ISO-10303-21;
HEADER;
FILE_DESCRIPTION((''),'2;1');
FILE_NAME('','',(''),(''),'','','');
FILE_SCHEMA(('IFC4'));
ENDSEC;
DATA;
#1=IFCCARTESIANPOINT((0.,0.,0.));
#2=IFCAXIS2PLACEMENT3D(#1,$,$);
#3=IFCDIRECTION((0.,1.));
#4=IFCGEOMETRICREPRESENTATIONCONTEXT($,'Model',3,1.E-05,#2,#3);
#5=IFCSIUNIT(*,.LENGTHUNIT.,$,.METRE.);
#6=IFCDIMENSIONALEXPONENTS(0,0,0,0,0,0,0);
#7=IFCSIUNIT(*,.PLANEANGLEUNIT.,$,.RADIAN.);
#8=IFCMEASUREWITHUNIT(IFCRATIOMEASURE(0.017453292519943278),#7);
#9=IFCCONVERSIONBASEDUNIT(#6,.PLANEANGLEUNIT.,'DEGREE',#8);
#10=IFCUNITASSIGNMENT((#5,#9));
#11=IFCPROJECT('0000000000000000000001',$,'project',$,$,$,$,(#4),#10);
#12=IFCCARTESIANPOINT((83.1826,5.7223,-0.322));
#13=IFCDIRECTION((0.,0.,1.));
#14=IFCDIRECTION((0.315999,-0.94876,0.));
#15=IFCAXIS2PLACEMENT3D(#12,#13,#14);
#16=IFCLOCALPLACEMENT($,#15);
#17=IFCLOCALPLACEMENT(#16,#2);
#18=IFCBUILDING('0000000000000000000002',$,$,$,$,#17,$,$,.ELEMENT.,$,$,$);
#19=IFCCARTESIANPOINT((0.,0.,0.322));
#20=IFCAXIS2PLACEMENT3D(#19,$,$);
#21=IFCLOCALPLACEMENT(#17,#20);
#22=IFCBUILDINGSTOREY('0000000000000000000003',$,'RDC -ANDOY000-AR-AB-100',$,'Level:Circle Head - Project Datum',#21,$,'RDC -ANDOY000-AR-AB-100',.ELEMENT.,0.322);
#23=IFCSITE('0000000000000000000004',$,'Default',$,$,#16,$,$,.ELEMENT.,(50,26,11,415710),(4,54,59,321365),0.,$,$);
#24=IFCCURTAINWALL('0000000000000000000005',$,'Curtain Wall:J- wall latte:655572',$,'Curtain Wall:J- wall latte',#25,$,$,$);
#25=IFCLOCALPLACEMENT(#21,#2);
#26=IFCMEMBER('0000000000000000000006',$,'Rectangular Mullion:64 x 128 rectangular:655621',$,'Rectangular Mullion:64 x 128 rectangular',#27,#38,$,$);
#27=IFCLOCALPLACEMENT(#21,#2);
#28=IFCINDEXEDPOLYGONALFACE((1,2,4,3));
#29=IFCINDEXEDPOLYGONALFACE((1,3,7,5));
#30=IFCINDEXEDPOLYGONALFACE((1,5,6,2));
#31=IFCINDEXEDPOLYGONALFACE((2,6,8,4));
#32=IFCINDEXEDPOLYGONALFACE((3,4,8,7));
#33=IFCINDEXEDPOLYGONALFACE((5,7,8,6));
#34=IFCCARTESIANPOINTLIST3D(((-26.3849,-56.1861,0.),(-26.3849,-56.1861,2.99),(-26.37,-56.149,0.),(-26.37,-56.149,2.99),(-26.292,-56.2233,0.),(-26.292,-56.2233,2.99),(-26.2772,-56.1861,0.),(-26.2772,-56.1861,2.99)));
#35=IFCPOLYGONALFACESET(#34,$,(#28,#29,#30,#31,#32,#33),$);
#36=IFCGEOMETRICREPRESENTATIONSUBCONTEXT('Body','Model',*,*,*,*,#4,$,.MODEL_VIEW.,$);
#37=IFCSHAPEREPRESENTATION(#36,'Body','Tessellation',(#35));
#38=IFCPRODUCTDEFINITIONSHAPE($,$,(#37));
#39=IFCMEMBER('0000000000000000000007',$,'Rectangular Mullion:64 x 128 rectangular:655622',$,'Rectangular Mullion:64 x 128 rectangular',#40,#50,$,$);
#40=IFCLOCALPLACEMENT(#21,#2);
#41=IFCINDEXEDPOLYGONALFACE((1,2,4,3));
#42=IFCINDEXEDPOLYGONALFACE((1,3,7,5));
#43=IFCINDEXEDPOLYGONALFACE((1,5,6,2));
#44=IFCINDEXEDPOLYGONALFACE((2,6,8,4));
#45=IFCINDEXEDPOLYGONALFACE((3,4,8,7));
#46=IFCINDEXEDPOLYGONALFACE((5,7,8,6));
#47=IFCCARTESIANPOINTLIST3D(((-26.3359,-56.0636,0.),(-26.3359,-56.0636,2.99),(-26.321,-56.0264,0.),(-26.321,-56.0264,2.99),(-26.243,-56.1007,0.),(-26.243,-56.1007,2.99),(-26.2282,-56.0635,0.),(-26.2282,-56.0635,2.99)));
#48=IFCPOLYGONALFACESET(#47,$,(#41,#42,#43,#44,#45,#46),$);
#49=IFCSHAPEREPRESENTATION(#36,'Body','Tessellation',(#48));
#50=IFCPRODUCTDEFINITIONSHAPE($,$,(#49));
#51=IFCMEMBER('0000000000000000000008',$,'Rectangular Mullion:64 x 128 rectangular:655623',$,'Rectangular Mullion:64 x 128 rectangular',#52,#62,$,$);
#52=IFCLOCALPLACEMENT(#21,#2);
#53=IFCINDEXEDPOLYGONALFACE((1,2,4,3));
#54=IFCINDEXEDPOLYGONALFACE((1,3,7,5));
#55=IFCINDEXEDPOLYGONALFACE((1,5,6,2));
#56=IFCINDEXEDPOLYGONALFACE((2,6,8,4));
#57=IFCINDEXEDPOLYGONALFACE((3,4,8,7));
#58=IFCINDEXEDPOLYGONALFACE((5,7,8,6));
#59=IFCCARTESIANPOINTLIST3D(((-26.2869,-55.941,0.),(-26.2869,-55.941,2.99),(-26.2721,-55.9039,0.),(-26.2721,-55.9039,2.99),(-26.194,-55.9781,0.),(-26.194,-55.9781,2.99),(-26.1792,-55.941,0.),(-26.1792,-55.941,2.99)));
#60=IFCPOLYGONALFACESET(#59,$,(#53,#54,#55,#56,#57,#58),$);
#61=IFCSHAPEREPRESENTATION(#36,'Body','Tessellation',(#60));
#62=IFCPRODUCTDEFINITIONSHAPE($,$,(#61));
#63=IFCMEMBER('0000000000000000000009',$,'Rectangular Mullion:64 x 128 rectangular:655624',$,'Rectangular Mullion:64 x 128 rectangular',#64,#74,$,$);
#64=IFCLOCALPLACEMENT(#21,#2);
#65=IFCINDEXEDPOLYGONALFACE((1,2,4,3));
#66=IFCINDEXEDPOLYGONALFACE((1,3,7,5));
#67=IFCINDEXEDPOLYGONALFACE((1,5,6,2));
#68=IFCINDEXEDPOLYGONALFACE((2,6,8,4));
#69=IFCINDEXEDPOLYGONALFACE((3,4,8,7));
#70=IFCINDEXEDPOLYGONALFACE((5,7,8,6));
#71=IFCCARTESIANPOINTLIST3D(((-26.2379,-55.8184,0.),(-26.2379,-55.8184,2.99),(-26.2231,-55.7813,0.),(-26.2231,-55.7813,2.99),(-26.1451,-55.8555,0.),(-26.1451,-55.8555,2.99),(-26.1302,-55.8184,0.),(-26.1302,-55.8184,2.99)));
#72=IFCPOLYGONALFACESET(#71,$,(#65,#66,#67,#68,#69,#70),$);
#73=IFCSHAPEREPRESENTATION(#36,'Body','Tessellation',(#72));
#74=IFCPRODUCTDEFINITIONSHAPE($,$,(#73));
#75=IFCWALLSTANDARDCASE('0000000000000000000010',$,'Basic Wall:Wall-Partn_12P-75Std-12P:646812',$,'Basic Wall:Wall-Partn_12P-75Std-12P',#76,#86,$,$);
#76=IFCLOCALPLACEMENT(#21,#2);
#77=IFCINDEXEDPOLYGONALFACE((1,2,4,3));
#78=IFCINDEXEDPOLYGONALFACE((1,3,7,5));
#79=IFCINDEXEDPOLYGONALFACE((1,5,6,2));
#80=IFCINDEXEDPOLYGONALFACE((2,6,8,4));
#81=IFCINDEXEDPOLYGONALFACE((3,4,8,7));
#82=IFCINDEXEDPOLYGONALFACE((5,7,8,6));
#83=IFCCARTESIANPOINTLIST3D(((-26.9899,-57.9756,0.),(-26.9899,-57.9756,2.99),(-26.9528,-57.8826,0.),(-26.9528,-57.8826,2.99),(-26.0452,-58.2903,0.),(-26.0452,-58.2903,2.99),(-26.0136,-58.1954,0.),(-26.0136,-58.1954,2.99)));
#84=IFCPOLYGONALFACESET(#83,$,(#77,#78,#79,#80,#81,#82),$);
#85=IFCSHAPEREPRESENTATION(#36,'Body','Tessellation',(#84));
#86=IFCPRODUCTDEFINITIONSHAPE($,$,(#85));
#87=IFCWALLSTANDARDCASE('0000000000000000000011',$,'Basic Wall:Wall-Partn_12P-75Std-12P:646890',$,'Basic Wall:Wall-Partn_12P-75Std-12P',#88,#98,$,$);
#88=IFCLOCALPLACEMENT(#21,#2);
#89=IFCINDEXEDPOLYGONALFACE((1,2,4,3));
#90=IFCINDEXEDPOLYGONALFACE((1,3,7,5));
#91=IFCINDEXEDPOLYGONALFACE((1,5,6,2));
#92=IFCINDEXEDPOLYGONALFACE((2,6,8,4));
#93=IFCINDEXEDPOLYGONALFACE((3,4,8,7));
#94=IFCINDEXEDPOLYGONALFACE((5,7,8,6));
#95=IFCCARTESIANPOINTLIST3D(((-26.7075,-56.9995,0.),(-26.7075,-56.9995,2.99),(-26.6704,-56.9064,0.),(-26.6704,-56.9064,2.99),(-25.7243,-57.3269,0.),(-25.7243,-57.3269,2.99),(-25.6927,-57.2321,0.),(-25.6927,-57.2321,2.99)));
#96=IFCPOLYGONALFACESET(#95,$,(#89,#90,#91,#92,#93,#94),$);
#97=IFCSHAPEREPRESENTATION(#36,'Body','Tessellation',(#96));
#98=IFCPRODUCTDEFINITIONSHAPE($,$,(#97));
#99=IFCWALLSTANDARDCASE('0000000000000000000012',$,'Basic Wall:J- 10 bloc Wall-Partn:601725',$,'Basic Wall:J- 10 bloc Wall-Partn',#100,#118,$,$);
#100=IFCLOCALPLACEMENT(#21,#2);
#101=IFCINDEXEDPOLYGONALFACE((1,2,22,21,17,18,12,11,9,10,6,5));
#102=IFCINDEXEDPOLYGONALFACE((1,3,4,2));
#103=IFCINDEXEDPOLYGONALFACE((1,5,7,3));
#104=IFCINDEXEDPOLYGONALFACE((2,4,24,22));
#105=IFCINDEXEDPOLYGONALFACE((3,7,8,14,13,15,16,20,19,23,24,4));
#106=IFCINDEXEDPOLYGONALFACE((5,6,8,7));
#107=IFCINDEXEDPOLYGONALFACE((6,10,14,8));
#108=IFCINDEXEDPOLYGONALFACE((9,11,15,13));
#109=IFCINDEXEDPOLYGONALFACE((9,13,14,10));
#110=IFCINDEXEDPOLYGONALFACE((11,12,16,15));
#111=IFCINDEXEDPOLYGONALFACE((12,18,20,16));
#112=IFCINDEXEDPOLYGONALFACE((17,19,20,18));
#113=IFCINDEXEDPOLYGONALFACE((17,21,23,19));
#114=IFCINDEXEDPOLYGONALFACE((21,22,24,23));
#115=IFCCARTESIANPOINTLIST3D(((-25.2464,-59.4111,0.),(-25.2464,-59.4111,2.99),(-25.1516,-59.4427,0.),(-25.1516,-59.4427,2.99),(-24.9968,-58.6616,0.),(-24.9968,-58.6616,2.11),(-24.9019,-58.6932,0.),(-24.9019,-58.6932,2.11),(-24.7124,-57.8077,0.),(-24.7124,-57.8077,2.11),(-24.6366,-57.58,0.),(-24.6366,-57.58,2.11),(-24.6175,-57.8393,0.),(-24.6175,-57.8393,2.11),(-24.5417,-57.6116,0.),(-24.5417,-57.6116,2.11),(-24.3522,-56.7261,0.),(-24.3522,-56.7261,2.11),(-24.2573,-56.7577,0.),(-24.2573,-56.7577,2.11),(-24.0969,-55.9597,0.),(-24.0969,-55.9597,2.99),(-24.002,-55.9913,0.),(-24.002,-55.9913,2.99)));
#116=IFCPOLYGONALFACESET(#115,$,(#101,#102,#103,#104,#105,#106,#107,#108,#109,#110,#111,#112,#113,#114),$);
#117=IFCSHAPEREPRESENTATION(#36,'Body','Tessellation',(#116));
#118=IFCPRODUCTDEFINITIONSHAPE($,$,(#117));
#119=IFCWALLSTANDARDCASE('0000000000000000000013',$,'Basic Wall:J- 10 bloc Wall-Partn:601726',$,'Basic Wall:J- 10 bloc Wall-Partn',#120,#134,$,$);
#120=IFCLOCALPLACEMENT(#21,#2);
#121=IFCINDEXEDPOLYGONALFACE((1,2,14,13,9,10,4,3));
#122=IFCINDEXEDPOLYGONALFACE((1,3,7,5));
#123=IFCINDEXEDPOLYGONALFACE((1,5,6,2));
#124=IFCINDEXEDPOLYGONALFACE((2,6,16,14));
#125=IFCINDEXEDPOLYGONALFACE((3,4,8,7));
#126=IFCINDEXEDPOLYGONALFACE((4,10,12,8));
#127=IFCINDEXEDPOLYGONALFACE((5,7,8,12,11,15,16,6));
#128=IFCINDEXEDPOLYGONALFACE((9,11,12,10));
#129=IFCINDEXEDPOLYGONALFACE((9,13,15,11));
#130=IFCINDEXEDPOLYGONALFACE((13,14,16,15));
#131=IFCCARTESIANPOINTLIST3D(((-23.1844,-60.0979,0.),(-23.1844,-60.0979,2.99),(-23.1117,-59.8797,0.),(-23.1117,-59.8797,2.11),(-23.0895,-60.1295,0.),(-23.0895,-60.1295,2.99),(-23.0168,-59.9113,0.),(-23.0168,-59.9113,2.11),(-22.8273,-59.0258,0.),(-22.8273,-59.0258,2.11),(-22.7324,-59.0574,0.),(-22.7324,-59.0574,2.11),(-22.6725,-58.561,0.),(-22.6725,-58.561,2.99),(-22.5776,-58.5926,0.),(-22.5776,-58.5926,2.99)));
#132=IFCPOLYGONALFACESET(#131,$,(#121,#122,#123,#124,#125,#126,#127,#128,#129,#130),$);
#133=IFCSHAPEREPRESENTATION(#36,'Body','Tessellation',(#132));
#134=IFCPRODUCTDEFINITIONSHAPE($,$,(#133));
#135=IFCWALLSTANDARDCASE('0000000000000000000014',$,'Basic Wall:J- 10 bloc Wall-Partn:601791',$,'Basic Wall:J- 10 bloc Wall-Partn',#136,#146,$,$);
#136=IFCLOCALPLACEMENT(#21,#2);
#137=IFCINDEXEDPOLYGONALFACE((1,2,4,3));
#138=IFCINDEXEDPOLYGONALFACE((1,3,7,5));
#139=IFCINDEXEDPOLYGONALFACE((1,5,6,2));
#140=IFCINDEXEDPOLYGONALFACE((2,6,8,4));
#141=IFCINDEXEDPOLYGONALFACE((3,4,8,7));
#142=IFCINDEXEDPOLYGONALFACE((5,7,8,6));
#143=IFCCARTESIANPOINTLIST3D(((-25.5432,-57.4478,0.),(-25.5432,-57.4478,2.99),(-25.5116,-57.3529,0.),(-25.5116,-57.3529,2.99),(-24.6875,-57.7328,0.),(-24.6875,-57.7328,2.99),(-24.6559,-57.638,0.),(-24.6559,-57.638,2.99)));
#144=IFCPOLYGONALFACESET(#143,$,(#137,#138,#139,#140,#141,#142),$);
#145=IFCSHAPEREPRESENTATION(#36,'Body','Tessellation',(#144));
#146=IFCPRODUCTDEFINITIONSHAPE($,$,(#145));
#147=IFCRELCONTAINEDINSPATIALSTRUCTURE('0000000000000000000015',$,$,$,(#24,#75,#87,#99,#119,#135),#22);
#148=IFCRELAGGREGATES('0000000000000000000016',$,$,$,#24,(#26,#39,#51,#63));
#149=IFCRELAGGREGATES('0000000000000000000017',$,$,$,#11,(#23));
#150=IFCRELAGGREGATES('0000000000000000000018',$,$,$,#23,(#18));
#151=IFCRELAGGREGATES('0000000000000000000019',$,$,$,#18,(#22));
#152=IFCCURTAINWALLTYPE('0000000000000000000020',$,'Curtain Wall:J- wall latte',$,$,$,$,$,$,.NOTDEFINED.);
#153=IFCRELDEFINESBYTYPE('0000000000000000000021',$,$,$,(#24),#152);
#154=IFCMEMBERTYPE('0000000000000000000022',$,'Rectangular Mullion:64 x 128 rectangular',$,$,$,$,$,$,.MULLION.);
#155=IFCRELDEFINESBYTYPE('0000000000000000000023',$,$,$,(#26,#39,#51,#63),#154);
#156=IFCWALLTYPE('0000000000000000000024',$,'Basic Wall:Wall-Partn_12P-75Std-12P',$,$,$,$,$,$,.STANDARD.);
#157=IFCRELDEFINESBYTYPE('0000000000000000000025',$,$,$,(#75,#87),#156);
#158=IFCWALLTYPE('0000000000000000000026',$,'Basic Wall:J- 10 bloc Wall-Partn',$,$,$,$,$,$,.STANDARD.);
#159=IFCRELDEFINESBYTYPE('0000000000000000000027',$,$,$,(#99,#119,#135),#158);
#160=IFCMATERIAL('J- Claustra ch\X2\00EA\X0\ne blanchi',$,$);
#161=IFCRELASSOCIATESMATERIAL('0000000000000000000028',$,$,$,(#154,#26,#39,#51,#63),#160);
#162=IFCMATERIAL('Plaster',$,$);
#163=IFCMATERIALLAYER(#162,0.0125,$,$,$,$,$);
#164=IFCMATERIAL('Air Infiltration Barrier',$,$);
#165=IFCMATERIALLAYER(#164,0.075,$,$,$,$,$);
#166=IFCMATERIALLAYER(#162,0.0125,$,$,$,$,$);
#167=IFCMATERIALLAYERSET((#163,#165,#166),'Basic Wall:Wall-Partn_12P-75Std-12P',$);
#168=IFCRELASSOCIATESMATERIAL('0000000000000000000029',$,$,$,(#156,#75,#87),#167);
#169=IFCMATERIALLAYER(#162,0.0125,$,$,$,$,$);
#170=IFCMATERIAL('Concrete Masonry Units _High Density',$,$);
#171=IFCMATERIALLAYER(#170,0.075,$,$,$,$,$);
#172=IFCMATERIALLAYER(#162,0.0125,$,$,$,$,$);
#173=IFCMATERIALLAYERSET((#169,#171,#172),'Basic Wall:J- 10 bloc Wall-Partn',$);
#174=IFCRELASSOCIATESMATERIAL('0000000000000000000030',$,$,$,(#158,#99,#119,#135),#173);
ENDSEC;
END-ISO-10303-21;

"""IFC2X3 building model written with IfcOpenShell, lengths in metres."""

from ifc_helpers import new_model, entity, si_unit, converted_unit, direction, frame, frame_2d, origin, origin_2d_with_axis, place, context, subcontext, project, spatial, polyline, rectangle, outline, extrude, clip, bounded_halfspace, source, transform, mapped, material, layer, layer_set, layer_usage, type_object, type_shapes, element, aggregate, save


model = new_model("IFC2X3")

# Units and contexts
model_context = context("Model", 3, precision=1e-05, world=origin(), true_north=direction((0.0, 1.0)))
body_context = subcontext(model_context, "Body", "Model", "MODEL_VIEW")
ifc_project = project(units=[si_unit("LENGTHUNIT", "METRE"), converted_unit("PLANEANGLEUNIT", "DEGREE", entity("IfcRatioMeasure", 0.017453292519943278), si_unit("PLANEANGLEUNIT", "RADIAN"), dimensions=[0, 0, 0, 0, 0, 0, 0])], contexts=[model_context])

# Site, building, storey
site_placement = place(None, frame((83.1826, 5.7223, -0.322), z_axis=(0.0, 0.0, 1.0), x_axis=(0.315999, -0.94876, 0.0)))
site = spatial("IfcSite", under=ifc_project, at=site_placement, Name="Default", CompositionType="ELEMENT", RefLatitude=(50, 26, 11, 415710), RefLongitude=(4, 54, 59, 321365), RefElevation=0.0)
building_placement = place(site_placement, origin())
building = spatial("IfcBuilding", under=site, at=building_placement, CompositionType="ELEMENT")
storey_placement = place(building_placement, frame((0.0, 0.0, 0.322)))
storey = spatial("IfcBuildingStorey", under=building, at=storey_placement, Name="RDC -ANDOY000-AR-AB-100", ObjectType="Level:Circle Head - Project Datum", LongName="RDC -ANDOY000-AR-AB-100", CompositionType="ELEMENT", Elevation=0.322)

# Curtain wall, members
curtain_wall_type = type_object("IfcCurtainWallType", Name="Curtain Wall:J- wall latte", PredefinedType="NOTDEFINED")
curtain_wall_placement = place(storey_placement, frame((0.0, 0.0, -0.322)))
curtain_wall = element("IfcCurtainWall", 1, at=curtain_wall_placement, inside=storey, type_object=curtain_wall_type, Name="Curtain Wall:J- wall latte:655572", ObjectType="Curtain Wall:J- wall latte")
ifc_material_1 = material(Name="J- Claustra chêne blanchi")
member_type = type_object("IfcMemberType", Name="Rectangular Mullion:64 x 128 rectangular", PredefinedType="MULLION", material=ifc_material_1)
shared_shape_1 = source(origin(), body_context, "Body", "SweptSolid", [
    extrude(rectangle(XDim=0.1, YDim=0.04, at=origin_2d_with_axis()), frame((0.0, 0.0, -2.99), z_axis=(0.0, 0.0, 1.0), x_axis=(0.0, -1.0, 0.0)), (0.0, 0.0, 1.0), 2.99),
])
type_shapes(member_type, [shared_shape_1])
member_1_placement = place(curtain_wall_placement, frame((-26.331, -56.1861, 0.322), z_axis=(0.0, 0.0, -1.0), x_axis=(0.371101, 0.928592, 0.0)))
member_1 = element("IfcMember", 2, at=member_1_placement, type_object=member_type, material=ifc_material_1, Name="Rectangular Mullion:64 x 128 rectangular:655621", ObjectType="Rectangular Mullion:64 x 128 rectangular", context=body_context, shape_type="MappedRepresentation", body=[
    mapped(shared_shape_1, transform((0.0, 0.0, 0.0), scale=1.0)),
])
member_2_placement = place(curtain_wall_placement, frame((-26.282, -56.0636, 0.322), z_axis=(0.0, 0.0, -1.0), x_axis=(0.371101, 0.928592, 0.0)))
member_2 = element("IfcMember", 3, at=member_2_placement, type_object=member_type, material=ifc_material_1, Name="Rectangular Mullion:64 x 128 rectangular:655622", ObjectType="Rectangular Mullion:64 x 128 rectangular", context=body_context, shape_type="MappedRepresentation", body=[
    mapped(shared_shape_1, transform((0.0, 0.0, 0.0), scale=1.0)),
])
member_3_placement = place(curtain_wall_placement, frame((-26.2331, -55.941, 0.322), z_axis=(0.0, 0.0, -1.0), x_axis=(0.371101, 0.928592, 0.0)))
member_3 = element("IfcMember", 4, at=member_3_placement, type_object=member_type, material=ifc_material_1, Name="Rectangular Mullion:64 x 128 rectangular:655623", ObjectType="Rectangular Mullion:64 x 128 rectangular", context=body_context, shape_type="MappedRepresentation", body=[
    mapped(shared_shape_1, transform((0.0, 0.0, 0.0), scale=1.0)),
])
member_4_placement = place(curtain_wall_placement, frame((-26.1841, -55.8184, 0.322), z_axis=(0.0, 0.0, -1.0), x_axis=(0.371101, 0.928592, 0.0)))
member_4 = element("IfcMember", 5, at=member_4_placement, type_object=member_type, material=ifc_material_1, Name="Rectangular Mullion:64 x 128 rectangular:655624", ObjectType="Rectangular Mullion:64 x 128 rectangular", context=body_context, shape_type="MappedRepresentation", body=[
    mapped(shared_shape_1, transform((0.0, 0.0, 0.0), scale=1.0)),
])
aggregate(curtain_wall, [member_1, member_2, member_3, member_4])

# Walls
ifc_material_2 = material(Name="Plaster")
ifc_layer_1 = layer(ifc_material_2, 0.0125)
ifc_material_3 = material(Name="Air Infiltration Barrier")
ifc_layer_2 = layer(ifc_material_3, 0.075)
ifc_layer_3 = layer(ifc_material_2, 0.0125)
ifc_layer_set_1 = layer_set([ifc_layer_1, ifc_layer_2, ifc_layer_3], Name="Basic Wall:Wall-Partn_12P-75Std-12P")
ifc_layer_usage_1 = layer_usage(ifc_layer_set_1, "AXIS2", "NEGATIVE", 0.05)
wall_type_1 = type_object("IfcWallType", Name="Basic Wall:Wall-Partn_12P-75Std-12P", PredefinedType="STANDARD", material=ifc_layer_set_1)
wall_1_placement = place(storey_placement, frame((-26.0294, -58.2428, 0.0), z_axis=(0.0, 0.0, 1.0), x_axis=(-0.948759, 0.316, 0.0)))
element("IfcWallStandardCase", 6, at=wall_1_placement, inside=storey, type_object=wall_type_1, material=ifc_layer_usage_1, Name="Basic Wall:Wall-Partn_12P-75Std-12P:646812", ObjectType="Basic Wall:Wall-Partn_12P-75Std-12P", context=body_context, shape_type="Clipping", body=[
    clip(extrude(outline(polyline([(0.9899, -0.05), (0.9958, 0.05), (0.0, 0.05), (0.0, -0.05), (0.9899, -0.05)])), origin(), (0.0, 0.0, 1.0), 2.99), bounded_halfspace(frame((0.0, -0.05, 2.99), z_axis=(0.0, 0.0, -1.0), x_axis=(-1.0, 0.0, 0.0)), True, frame((0.0, -0.05, 2.99)), polyline([(0.0, 0.0), (0.9899, 0.0), (0.9958, 0.1), (0.0, 0.1), (0.0, 0.0)]))),
])
wall_2_placement = place(storey_placement, frame((-25.7085, -57.2795, 0.0), z_axis=(0.0, 0.0, 1.0), x_axis=(-0.948759, 0.316, 0.0)))
element("IfcWallStandardCase", 7, at=wall_2_placement, inside=storey, type_object=wall_type_1, material=ifc_layer_usage_1, Name="Basic Wall:Wall-Partn_12P-75Std-12P:646890", ObjectType="Basic Wall:Wall-Partn_12P-75Std-12P", context=body_context, shape_type="Clipping", body=[
    clip(extrude(outline(polyline([(1.0304, -0.05), (1.0363, 0.05), (0.9361, 0.05), (0.0, 0.05), (0.0, -0.05), (1.0304, -0.05)])), origin(), (0.0, 0.0, 1.0), 2.99), bounded_halfspace(frame((0.0, -0.05, 2.99), z_axis=(0.0, 0.0, -1.0), x_axis=(-1.0, 0.0, 0.0)), True, frame((0.0, -0.05, 2.99)), polyline([(0.0, 0.0), (1.0304, 0.0), (1.0363, 0.1), (0.9361, 0.1), (0.0, 0.1), (0.0, 0.0)]))),
])

# Wall, openings
ifc_layer_4 = layer(ifc_material_2, 0.0125)
ifc_material_4 = material(Name="Concrete Masonry Units _High Density")
ifc_layer_5 = layer(ifc_material_4, 0.075)
ifc_layer_6 = layer(ifc_material_2, 0.0125)
ifc_layer_set_2 = layer_set([ifc_layer_4, ifc_layer_5, ifc_layer_6], Name="Basic Wall:J- 10 bloc Wall-Partn")
ifc_layer_usage_2 = layer_usage(ifc_layer_set_2, "AXIS2", "NEGATIVE", 0.05)
wall_type_2 = type_object("IfcWallType", Name="Basic Wall:J- 10 bloc Wall-Partn", PredefinedType="STANDARD", material=ifc_layer_set_2)
wall_3_placement = place(storey_placement, frame((-24.0494, -55.9755, 0.0), z_axis=(0.0, 0.0, 1.0), x_axis=(-0.316, -0.948759, 0.0)))
wall_3 = element("IfcWallStandardCase", 8, at=wall_3_placement, inside=storey, type_object=wall_type_2, material=ifc_layer_usage_2, Name="Basic Wall:J- 10 bloc Wall-Partn:601725", ObjectType="Basic Wall:J- 10 bloc Wall-Partn", context=body_context, shape_type="Clipping", body=[
    clip(extrude(rectangle(XDim=3.6379, YDim=0.1, at=frame_2d((1.8189, 0.0), x_axis=(1.0, 0.0))), origin(), (0.0, 0.0, 1.0), 2.99), bounded_halfspace(frame((0.0, -0.05, 2.99), z_axis=(0.0, 0.0, -1.0), x_axis=(0.0, 1.0, 0.0)), True, frame((0.0, -0.05, 2.99)), polyline([(0.0, 0.0), (1.7689, 0.0), (1.8689, 0.0), (3.6379, 0.0), (3.6379, 0.1), (0.0, 0.1), (0.0, 0.0)]))),
])
opening_1_placement = place(wall_3_placement, frame((1.9479, -0.05, 0.0)))
element("IfcOpeningElement", 9, at=opening_1_placement, cuts=wall_3, ObjectType="Opening", context=body_context, shape_type="SweptSolid", body=[
    extrude(rectangle(XDim=2.11, YDim=0.9, at=frame_2d((1.055, 0.45), x_axis=(1.0, 0.0))), frame((0.0, 0.0, 0.0), z_axis=(0.0, 1.0, 0.0), x_axis=(0.0, 0.0, 1.0)), (0.0, 0.0, 1.0), 0.1),
])
opening_2_placement = place(wall_3_placement, frame((0.8079, -0.05, 0.0)))
element("IfcOpeningElement", 10, at=opening_2_placement, cuts=wall_3, ObjectType="Opening", context=body_context, shape_type="SweptSolid", body=[
    extrude(rectangle(XDim=2.11, YDim=0.9, at=frame_2d((1.055, 0.45), x_axis=(1.0, 0.0))), frame((0.0, 0.0, 0.0), z_axis=(0.0, 1.0, 0.0), x_axis=(0.0, 0.0, 1.0)), (0.0, 0.0, 1.0), 0.1),
])

# Wall, opening
wall_4_placement = place(storey_placement, frame((-22.6251, -58.5768, 0.0), z_axis=(0.0, 0.0, 1.0), x_axis=(-0.316, -0.948759, 0.0)))
wall_4 = element("IfcWallStandardCase", 11, at=wall_4_placement, inside=storey, type_object=wall_type_2, material=ifc_layer_usage_2, Name="Basic Wall:J- 10 bloc Wall-Partn:601726", ObjectType="Basic Wall:J- 10 bloc Wall-Partn", context=body_context, shape_type="Clipping", body=[
    clip(extrude(rectangle(XDim=1.6199, YDim=0.1, at=frame_2d((0.8099, 0.0), x_axis=(1.0, 0.0))), origin(), (0.0, 0.0, 1.0), 2.99), bounded_halfspace(frame((0.0, -0.05, 2.99), z_axis=(0.0, 0.0, -1.0), x_axis=(0.0, 1.0, 0.0)), True, frame((0.0, -0.05, 2.99)), polyline([(0.0, 0.0), (1.6199, 0.0), (1.6199, 0.1), (0.0, 0.1), (0.0, 0.0)]))),
])
opening_3_placement = place(wall_4_placement, frame((1.3899, 0.05, 0.0)))
element("IfcOpeningElement", 12, at=opening_3_placement, cuts=wall_4, ObjectType="Opening", context=body_context, shape_type="SweptSolid", body=[
    extrude(rectangle(XDim=2.11, YDim=0.9, at=frame_2d((1.055, 0.45), x_axis=(1.0, 0.0))), frame((0.0, 0.0, 0.0), z_axis=(0.0, -1.0, 0.0), x_axis=(0.0, 0.0, 1.0)), (0.0, 0.0, 1.0), 0.1),
])

# Wall
wall_5_placement = place(storey_placement, frame((-24.6717, -57.6854, 0.0), z_axis=(0.0, 0.0, 1.0), x_axis=(-0.948759, 0.316, 0.0)))
element("IfcWallStandardCase", 13, at=wall_5_placement, inside=storey, type_object=wall_type_2, material=ifc_layer_usage_2, Name="Basic Wall:J- 10 bloc Wall-Partn:601791", ObjectType="Basic Wall:J- 10 bloc Wall-Partn", context=body_context, shape_type="Clipping", body=[
    clip(extrude(rectangle(XDim=0.902, YDim=0.1, at=frame_2d((0.451, 0.0), x_axis=(-1.0, 0.0))), origin(), (0.0, 0.0, 1.0), 2.99), bounded_halfspace(frame((0.0, -0.05, 2.99), z_axis=(0.0, 0.0, -1.0), x_axis=(-1.0, 0.0, 0.0)), True, frame((0.0, -0.05, 2.99)), polyline([(0.0, 0.0), (0.902, 0.0), (0.902, 0.1), (0.0, 0.1), (0.0, 0.0)]))),
])

save(model, "model.ifc")
